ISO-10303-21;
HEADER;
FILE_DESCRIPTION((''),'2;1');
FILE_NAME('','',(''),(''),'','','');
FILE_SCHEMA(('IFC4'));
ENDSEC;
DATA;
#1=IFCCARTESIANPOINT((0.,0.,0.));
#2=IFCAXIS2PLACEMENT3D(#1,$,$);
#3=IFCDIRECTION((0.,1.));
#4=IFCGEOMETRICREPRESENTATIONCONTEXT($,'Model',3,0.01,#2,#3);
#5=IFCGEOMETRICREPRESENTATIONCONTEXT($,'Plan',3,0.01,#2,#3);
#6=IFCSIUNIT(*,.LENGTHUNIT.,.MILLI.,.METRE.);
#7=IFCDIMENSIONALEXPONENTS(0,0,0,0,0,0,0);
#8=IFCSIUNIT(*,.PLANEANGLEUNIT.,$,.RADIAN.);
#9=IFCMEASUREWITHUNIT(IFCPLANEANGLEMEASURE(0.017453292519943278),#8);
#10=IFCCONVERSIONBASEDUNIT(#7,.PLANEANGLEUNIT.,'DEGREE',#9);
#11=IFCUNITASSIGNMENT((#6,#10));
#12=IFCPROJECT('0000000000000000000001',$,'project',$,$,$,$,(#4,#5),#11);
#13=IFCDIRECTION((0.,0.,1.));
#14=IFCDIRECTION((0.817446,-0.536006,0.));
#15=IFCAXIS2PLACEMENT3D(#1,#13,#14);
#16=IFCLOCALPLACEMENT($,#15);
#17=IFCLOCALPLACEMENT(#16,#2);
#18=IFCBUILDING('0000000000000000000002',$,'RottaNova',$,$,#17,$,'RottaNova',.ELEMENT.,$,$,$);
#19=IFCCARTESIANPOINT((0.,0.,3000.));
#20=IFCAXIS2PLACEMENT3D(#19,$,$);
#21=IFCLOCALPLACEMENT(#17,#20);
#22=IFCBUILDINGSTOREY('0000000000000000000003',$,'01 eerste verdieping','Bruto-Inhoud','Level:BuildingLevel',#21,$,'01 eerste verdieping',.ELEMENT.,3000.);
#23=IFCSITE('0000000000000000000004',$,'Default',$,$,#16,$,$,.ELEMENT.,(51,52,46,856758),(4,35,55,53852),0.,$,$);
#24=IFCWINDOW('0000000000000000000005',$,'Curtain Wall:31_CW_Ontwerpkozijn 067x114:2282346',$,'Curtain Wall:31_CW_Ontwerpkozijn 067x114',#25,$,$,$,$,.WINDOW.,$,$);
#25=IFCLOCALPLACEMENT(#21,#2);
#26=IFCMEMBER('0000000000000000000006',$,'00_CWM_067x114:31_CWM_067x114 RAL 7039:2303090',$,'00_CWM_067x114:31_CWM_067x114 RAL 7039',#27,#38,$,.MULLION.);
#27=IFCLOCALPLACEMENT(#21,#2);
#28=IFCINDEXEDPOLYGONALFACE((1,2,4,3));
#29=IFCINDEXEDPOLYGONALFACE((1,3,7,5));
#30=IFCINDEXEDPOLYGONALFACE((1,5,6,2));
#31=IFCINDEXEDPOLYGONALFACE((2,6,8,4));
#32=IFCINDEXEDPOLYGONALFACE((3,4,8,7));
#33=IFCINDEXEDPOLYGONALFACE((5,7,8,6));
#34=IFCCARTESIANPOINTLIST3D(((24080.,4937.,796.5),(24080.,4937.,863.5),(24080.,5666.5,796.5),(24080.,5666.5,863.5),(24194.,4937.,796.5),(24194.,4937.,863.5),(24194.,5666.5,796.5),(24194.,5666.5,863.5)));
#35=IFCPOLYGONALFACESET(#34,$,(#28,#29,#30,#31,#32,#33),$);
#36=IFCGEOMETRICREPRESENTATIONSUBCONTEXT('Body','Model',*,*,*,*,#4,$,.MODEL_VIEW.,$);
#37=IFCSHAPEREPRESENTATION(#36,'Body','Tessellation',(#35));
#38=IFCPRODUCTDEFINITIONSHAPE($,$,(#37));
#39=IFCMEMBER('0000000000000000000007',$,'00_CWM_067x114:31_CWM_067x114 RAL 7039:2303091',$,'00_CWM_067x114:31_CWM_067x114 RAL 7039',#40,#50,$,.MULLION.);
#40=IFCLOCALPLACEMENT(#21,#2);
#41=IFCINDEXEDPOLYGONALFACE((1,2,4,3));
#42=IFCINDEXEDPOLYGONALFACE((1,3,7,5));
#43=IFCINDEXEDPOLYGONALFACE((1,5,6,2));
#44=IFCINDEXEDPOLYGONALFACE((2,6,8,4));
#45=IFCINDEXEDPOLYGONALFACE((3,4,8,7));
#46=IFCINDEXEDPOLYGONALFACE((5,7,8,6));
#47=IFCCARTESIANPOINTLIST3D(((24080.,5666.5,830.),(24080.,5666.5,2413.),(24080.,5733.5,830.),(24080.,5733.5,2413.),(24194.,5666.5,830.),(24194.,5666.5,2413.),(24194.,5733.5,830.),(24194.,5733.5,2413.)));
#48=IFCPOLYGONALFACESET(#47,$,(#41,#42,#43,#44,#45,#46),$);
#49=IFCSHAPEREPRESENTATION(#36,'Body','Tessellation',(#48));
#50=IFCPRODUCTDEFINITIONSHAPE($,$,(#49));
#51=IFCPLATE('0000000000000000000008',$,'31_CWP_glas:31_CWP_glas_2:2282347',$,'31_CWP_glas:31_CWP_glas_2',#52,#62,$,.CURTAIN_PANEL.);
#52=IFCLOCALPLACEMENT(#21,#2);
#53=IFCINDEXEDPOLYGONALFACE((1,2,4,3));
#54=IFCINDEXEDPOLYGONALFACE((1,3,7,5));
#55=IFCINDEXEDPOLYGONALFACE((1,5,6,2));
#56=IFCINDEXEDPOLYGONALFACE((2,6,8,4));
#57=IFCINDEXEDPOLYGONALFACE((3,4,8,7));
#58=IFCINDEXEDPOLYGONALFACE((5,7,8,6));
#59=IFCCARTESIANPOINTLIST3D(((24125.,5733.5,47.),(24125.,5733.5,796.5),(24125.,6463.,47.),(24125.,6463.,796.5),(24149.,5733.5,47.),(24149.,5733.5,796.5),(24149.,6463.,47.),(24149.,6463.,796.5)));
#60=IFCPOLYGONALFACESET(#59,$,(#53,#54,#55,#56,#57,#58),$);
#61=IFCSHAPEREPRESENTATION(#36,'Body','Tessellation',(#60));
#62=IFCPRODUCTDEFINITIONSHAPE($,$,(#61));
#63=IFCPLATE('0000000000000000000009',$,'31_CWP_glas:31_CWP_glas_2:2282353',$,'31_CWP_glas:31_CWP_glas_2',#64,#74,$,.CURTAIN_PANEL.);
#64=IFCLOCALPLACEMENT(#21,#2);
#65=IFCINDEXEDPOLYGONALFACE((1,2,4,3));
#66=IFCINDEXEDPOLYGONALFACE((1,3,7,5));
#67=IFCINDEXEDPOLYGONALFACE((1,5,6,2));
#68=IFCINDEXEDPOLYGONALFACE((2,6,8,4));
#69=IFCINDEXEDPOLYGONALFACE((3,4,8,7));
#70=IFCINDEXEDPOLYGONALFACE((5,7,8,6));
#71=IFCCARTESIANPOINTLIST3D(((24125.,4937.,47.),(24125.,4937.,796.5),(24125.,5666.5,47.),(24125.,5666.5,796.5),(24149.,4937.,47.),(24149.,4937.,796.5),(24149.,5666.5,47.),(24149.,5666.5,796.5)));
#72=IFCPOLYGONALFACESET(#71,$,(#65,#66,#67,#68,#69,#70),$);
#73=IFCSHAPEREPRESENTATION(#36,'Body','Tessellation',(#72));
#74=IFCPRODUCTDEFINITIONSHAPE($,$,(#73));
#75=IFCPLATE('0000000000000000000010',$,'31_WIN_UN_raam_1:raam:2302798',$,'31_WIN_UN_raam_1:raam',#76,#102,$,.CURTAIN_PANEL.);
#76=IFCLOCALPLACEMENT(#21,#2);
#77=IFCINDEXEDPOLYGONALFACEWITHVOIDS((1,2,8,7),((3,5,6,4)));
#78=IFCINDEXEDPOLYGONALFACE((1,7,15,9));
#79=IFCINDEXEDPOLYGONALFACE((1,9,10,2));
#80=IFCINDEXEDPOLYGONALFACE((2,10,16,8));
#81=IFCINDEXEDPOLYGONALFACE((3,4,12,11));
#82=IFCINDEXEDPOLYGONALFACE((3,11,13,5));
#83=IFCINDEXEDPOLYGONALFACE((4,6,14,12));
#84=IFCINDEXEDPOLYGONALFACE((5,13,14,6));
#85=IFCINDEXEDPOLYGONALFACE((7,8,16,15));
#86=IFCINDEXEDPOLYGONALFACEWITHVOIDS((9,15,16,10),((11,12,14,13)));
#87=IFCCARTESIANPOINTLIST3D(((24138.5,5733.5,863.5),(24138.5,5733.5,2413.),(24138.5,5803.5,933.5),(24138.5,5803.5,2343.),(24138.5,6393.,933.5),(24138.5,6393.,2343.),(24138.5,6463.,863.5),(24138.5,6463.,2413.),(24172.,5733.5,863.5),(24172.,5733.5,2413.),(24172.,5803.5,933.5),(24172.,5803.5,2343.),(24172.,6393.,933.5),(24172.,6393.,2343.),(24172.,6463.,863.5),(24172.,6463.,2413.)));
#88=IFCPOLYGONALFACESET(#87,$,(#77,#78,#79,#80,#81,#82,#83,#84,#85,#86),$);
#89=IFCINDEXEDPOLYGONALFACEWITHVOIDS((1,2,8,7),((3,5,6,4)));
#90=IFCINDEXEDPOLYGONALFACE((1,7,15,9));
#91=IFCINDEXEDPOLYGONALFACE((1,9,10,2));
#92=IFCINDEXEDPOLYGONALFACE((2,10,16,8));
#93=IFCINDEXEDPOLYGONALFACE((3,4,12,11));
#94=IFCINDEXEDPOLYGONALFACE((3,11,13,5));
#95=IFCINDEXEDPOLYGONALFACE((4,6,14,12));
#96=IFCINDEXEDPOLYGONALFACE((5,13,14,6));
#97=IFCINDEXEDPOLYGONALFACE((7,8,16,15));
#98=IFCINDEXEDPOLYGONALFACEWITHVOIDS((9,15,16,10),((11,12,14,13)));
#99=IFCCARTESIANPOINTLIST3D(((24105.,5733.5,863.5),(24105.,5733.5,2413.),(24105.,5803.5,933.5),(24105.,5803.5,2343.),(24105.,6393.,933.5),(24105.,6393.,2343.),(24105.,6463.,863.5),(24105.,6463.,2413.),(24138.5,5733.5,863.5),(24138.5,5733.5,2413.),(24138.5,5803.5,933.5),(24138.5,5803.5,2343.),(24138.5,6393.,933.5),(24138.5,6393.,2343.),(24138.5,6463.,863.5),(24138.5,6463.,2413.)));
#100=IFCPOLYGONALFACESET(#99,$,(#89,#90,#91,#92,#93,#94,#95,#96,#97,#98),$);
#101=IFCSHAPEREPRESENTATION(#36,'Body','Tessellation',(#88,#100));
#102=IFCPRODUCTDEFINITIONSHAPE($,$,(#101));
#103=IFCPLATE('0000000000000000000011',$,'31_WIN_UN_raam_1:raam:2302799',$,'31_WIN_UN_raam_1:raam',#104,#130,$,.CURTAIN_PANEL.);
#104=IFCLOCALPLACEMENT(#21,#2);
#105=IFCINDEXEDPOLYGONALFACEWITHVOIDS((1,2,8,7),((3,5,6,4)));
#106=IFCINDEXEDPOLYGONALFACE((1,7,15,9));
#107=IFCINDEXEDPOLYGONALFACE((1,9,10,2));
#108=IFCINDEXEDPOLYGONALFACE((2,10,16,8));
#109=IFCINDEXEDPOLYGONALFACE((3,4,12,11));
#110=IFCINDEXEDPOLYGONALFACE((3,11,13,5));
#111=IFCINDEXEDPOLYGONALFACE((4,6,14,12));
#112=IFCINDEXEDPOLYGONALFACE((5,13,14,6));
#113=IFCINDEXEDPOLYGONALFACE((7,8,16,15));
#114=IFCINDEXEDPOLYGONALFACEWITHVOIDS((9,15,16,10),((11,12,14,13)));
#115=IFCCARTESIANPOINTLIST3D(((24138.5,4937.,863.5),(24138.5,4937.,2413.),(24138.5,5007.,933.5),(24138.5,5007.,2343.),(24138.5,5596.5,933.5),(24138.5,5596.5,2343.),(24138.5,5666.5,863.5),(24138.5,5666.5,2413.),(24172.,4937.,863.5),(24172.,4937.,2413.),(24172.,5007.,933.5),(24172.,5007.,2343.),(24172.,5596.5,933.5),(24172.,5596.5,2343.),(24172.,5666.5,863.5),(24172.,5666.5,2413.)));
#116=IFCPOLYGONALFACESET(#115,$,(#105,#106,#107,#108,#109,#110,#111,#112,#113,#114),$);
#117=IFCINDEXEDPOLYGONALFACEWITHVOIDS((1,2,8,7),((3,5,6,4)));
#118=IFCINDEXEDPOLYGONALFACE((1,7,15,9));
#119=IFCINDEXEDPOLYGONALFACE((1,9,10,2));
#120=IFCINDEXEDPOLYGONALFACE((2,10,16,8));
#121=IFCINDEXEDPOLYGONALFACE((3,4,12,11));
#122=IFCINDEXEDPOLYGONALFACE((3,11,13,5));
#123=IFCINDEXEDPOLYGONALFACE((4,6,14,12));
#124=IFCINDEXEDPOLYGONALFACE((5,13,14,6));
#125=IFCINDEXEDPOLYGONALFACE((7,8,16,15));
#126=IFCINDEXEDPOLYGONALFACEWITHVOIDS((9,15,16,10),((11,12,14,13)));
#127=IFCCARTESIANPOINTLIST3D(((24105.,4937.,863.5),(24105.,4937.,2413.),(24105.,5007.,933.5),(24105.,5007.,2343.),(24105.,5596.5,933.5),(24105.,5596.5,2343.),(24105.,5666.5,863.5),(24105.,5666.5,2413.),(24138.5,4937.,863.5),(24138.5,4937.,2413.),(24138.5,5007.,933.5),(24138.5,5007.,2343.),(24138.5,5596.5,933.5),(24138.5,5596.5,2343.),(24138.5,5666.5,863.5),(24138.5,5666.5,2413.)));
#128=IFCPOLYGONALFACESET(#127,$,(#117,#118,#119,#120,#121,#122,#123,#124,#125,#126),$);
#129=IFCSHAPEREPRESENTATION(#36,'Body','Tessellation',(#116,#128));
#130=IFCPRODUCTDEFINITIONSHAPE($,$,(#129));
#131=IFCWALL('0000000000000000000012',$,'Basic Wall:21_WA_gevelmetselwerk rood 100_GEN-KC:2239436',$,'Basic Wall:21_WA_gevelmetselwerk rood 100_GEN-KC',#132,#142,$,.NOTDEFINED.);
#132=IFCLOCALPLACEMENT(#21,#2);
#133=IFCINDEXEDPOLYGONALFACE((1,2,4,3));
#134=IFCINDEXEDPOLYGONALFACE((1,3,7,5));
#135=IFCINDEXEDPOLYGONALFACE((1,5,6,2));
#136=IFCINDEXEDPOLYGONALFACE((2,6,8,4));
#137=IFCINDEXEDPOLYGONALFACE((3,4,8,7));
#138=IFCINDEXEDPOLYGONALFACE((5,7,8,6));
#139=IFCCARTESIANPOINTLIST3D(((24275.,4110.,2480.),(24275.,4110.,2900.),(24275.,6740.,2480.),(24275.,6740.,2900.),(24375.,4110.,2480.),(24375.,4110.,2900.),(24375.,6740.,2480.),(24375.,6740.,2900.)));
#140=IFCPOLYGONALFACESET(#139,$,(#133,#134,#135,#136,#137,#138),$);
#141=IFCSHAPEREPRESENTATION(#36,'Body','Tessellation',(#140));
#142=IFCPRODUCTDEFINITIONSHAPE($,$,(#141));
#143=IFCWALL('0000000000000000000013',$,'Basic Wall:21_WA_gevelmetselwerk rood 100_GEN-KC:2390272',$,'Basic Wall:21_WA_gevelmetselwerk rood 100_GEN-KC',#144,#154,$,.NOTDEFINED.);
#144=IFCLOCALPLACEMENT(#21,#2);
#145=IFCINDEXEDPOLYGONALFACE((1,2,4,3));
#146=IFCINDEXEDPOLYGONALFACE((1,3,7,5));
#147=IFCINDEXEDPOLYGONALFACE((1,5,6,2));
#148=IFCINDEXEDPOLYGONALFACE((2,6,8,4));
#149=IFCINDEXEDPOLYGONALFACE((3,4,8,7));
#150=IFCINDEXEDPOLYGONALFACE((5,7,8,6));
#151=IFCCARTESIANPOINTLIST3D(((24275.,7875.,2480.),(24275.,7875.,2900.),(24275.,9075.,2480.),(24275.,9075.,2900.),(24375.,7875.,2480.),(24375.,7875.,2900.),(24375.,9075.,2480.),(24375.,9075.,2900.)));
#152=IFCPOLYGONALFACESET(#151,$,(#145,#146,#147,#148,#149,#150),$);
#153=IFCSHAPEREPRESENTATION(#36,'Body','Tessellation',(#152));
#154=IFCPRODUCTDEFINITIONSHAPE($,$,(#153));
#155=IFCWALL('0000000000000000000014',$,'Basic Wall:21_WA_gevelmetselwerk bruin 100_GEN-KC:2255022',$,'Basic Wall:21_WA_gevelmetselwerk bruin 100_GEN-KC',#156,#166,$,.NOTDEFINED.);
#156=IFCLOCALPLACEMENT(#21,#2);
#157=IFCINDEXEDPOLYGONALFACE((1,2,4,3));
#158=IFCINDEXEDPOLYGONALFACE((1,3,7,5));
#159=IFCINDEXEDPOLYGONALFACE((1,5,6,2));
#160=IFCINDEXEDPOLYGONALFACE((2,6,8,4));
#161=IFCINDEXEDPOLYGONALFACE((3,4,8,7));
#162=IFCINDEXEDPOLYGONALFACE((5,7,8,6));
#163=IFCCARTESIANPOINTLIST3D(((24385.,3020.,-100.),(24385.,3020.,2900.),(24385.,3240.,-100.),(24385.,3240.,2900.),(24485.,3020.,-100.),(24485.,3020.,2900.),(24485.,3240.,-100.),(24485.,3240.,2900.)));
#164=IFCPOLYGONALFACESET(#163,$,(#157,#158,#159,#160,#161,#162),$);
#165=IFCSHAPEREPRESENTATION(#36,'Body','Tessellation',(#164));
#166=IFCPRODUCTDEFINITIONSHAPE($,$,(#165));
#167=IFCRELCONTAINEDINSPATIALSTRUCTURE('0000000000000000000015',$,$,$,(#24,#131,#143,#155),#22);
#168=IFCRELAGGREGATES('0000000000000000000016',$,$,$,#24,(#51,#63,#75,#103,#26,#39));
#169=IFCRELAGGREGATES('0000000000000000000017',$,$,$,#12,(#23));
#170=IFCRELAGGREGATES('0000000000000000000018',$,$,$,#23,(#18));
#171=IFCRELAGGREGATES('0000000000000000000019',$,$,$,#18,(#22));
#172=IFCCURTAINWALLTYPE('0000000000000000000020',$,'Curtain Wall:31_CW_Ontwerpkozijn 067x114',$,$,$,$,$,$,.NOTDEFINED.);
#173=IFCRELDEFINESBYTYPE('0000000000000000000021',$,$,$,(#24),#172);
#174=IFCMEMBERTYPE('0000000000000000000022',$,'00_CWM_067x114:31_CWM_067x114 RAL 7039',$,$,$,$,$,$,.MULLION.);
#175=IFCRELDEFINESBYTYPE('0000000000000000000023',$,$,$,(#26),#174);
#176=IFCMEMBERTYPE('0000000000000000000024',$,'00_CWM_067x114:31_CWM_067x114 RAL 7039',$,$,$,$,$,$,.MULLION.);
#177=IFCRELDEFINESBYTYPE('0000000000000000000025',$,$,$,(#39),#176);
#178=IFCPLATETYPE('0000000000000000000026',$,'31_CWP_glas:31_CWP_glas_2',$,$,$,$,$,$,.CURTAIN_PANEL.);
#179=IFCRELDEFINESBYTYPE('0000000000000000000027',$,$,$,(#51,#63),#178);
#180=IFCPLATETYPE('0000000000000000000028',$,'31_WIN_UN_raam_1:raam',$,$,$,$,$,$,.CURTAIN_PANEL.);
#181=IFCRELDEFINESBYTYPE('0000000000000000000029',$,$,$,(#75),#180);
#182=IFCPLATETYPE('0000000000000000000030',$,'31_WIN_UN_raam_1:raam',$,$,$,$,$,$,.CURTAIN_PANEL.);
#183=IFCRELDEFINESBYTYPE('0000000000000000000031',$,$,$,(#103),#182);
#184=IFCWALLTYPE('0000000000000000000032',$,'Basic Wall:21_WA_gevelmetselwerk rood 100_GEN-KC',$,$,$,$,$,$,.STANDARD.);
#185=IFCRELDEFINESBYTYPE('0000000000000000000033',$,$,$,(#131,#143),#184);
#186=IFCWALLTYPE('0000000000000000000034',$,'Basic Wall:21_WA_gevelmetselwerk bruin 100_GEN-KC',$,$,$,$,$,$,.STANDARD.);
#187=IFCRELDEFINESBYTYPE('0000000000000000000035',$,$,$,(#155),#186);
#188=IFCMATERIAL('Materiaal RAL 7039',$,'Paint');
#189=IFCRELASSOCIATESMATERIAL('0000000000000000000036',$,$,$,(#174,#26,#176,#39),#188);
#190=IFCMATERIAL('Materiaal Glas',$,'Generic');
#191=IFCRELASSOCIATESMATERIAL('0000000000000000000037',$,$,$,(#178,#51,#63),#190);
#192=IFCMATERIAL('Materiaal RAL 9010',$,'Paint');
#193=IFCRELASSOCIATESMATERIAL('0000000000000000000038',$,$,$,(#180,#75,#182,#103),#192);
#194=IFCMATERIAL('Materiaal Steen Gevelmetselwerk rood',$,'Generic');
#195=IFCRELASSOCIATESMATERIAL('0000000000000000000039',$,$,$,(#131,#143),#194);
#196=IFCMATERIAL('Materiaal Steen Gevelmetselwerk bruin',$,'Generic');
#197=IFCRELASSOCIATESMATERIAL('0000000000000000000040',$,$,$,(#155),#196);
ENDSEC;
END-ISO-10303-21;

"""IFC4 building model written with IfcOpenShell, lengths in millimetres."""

from ifc_helpers import new_model, entity, si_unit, converted_unit, direction, frame, origin, place, context, subcontext, project, spatial, indexed_curve, outline, extrude, source, transform, mapped, material, type_object, type_shapes, element, aggregate, save


model = new_model("IFC4")

# Units and contexts
model_context = context("Model", 3, precision=0.01, world=origin(), true_north=direction((0.0, 1.0)))
plan_context = context("Plan", 3, precision=0.01, world=origin(), true_north=direction((0.0, 1.0)))
body_context = subcontext(model_context, "Body", "Model", "MODEL_VIEW")
ifc_project = project(units=[si_unit("LENGTHUNIT", "METRE", prefix="MILLI"), converted_unit("PLANEANGLEUNIT", "DEGREE", entity("IfcPlaneAngleMeasure", 0.017453292519943278), si_unit("PLANEANGLEUNIT", "RADIAN"), dimensions=[0, 0, 0, 0, 0, 0, 0])], contexts=[model_context, plan_context])

# Site, building, storey
site_placement = place(None, frame((0.0, 0.0, 0.0), z_axis=(0.0, 0.0, 1.0), x_axis=(0.817446, -0.536006, 0.0)))
site = spatial("IfcSite", under=ifc_project, at=site_placement, Name="Default", CompositionType="ELEMENT", RefLatitude=(51, 52, 46, 856758), RefLongitude=(4, 35, 55, 53852), RefElevation=0.0)
building_placement = place(site_placement, origin())
building = spatial("IfcBuilding", under=site, at=building_placement, Name="RottaNova", LongName="RottaNova", CompositionType="ELEMENT")
storey_placement = place(building_placement, frame((0.0, 0.0, 3000.0)))
storey = spatial("IfcBuildingStorey", under=building, at=storey_placement, Name="01 eerste verdieping", Description="Bruto-Inhoud", ObjectType="Level:BuildingLevel", LongName="01 eerste verdieping", CompositionType="ELEMENT", Elevation=3000.0)

# Window, members, plates
curtain_wall_type = type_object("IfcCurtainWallType", Name="Curtain Wall:31_CW_Ontwerpkozijn 067x114", PredefinedType="NOTDEFINED")
window_placement = place(storey_placement, frame((0.0, 0.0, -3000.0)))
window = element("IfcWindow", 1, at=window_placement, inside=storey, type_object=curtain_wall_type, Name="Curtain Wall:31_CW_Ontwerpkozijn 067x114:2282346", ObjectType="Curtain Wall:31_CW_Ontwerpkozijn 067x114", PredefinedType="WINDOW")
ifc_material_1 = material(Name="Materiaal RAL 7039", Category="Paint")
member_type_1 = type_object("IfcMemberType", Name="00_CWM_067x114:31_CWM_067x114 RAL 7039", PredefinedType="MULLION", material=ifc_material_1)
shared_shape_1 = source(origin(), body_context, "Body", "SweptSolid", [
    extrude(outline(indexed_curve([(-33.5, -57.0), (33.5, -57.0), (33.5, 57.0), (-33.5, 57.0), (-33.5, -57.0)], self_intersect=False)), frame((0.0, -57.0, -729.5), z_axis=(0.0, 0.0, 1.0), x_axis=(-1.0, 0.0, 0.0)), (0.0, 0.0, 1.0), 729.5),
])
type_shapes(member_type_1, [shared_shape_1])
member_1_placement = place(window_placement, frame((24080.0, 4937.0, 3830.0), z_axis=(0.0, -1.0, 0.0), x_axis=(0.0, 0.0, 1.0)))
member_1 = element("IfcMember", 2, at=member_1_placement, type_object=member_type_1, material=ifc_material_1, Name="00_CWM_067x114:31_CWM_067x114 RAL 7039:2303090", ObjectType="00_CWM_067x114:31_CWM_067x114 RAL 7039", PredefinedType="MULLION", context=body_context, shape_type="MappedRepresentation", body=[
    mapped(shared_shape_1, transform((0.0, 0.0, 0.0), scale=1.0)),
])
member_type_2 = type_object("IfcMemberType", Name="00_CWM_067x114:31_CWM_067x114 RAL 7039", PredefinedType="MULLION", material=ifc_material_1)
shared_shape_2 = source(origin(), body_context, "Body", "SweptSolid", [
    extrude(outline(indexed_curve([(-33.5, -57.0), (33.5, -57.0), (33.5, 57.0), (-33.5, 57.0), (-33.5, -57.0)], self_intersect=False)), frame((0.0, -57.0, -1583.0), z_axis=(0.0, 0.0, 1.0), x_axis=(-1.0, 0.0, 0.0)), (0.0, 0.0, 1.0), 1583.0),
])
type_shapes(member_type_2, [shared_shape_2])
member_2_placement = place(window_placement, frame((24080.0, 5700.0, 3830.0), z_axis=(0.0, 0.0, -1.0), x_axis=(0.0, -1.0, 0.0)))
member_2 = element("IfcMember", 3, at=member_2_placement, type_object=member_type_2, material=ifc_material_1, Name="00_CWM_067x114:31_CWM_067x114 RAL 7039:2303091", ObjectType="00_CWM_067x114:31_CWM_067x114 RAL 7039", PredefinedType="MULLION", context=body_context, shape_type="MappedRepresentation", body=[
    mapped(shared_shape_2, transform((0.0, 0.0, 0.0), scale=1.0)),
])
ifc_material_2 = material(Name="Materiaal Glas", Category="Generic")
plate_type_1 = type_object("IfcPlateType", Name="31_CWP_glas:31_CWP_glas_2", PredefinedType="CURTAIN_PANEL", material=ifc_material_2)
shared_shape_3 = source(origin(), body_context, "Body", "SweptSolid", [
    extrude(outline(indexed_curve([(-12.0, -364.7), (12.0, -364.7), (12.0, 364.7), (-12.0, 364.7), (-12.0, -364.7)], self_intersect=False)), frame((0.0, 57.0, 0.0), z_axis=(0.0, 0.0, 1.0), x_axis=(0.0, 1.0, 0.0)), (0.0, 0.0, 1.0), 749.5),
])
type_shapes(plate_type_1, [shared_shape_3])
plate_1_placement = place(window_placement, frame((24080.0, 6098.2, 3047.0), z_axis=(0.0, 0.0, 1.0), x_axis=(0.0, -1.0, 0.0)))
plate_1 = element("IfcPlate", 4, at=plate_1_placement, type_object=plate_type_1, material=ifc_material_2, Name="31_CWP_glas:31_CWP_glas_2:2282347", ObjectType="31_CWP_glas:31_CWP_glas_2", PredefinedType="CURTAIN_PANEL", context=body_context, shape_type="MappedRepresentation", body=[
    mapped(shared_shape_3, transform((0.0, 0.0, 0.0), scale=1.0)),
])
plate_2_placement = place(window_placement, frame((24080.0, 5301.7, 3047.0), z_axis=(0.0, 0.0, 1.0), x_axis=(0.0, -1.0, 0.0)))
plate_2 = element("IfcPlate", 5, at=plate_2_placement, type_object=plate_type_1, material=ifc_material_2, Name="31_CWP_glas:31_CWP_glas_2:2282353", ObjectType="31_CWP_glas:31_CWP_glas_2", PredefinedType="CURTAIN_PANEL", context=body_context, shape_type="MappedRepresentation", body=[
    mapped(shared_shape_3, transform((0.0, 0.0, 0.0), scale=1.0)),
])
ifc_material_3 = material(Name="Materiaal RAL 9010", Category="Paint")
plate_type_2 = type_object("IfcPlateType", Name="31_WIN_UN_raam_1:raam", PredefinedType="CURTAIN_PANEL", material=ifc_material_3)
shared_shape_4 = source(origin(), body_context, "Body", "SweptSolid", [
    extrude(outline(indexed_curve([(-364.7, -774.7), (364.7, -774.7), (364.7, 774.7), (-364.7, 774.7), (-364.7, -774.7)], self_intersect=False), holes=[indexed_curve([(-294.7, 704.7), (294.7, 704.7), (294.7, -704.8), (-294.7, -704.8), (-294.7, 704.7)], self_intersect=False)]), frame((0.0, 58.5, 774.8), z_axis=(0.0, 1.0, 0.0), x_axis=(1.0, 0.0, 0.0)), (0.0, 0.0, 1.0), 33.5),
    extrude(outline(indexed_curve([(-364.7, -774.7), (364.7, -774.7), (364.7, 774.7), (-364.7, 774.7), (-364.7, -774.7)], self_intersect=False), holes=[indexed_curve([(-294.7, 704.7), (294.7, 704.7), (294.7, -704.8), (-294.7, -704.8), (-294.7, 704.7)], self_intersect=False)]), frame((0.0, 25.0, 774.8), z_axis=(0.0, 1.0, 0.0), x_axis=(1.0, 0.0, 0.0)), (0.0, 0.0, 1.0), 33.5),
])
type_shapes(plate_type_2, [shared_shape_4])
plate_3_placement = place(window_placement, frame((24080.0, 6098.2, 3863.5), z_axis=(0.0, 0.0, 1.0), x_axis=(0.0, -1.0, 0.0)))
plate_3 = element("IfcPlate", 6, at=plate_3_placement, type_object=plate_type_2, material=ifc_material_3, Name="31_WIN_UN_raam_1:raam:2302798", ObjectType="31_WIN_UN_raam_1:raam", PredefinedType="CURTAIN_PANEL", context=body_context, shape_type="MappedRepresentation", body=[
    mapped(shared_shape_4, transform((0.0, 0.0, 0.0), scale=1.0)),
])
plate_type_3 = type_object("IfcPlateType", Name="31_WIN_UN_raam_1:raam", PredefinedType="CURTAIN_PANEL", material=ifc_material_3)
shared_shape_5 = source(origin(), body_context, "Body", "SweptSolid", [
    extrude(outline(indexed_curve([(-364.7, -774.7), (364.7, -774.7), (364.7, 774.7), (-364.7, 774.7), (-364.7, -774.7)], self_intersect=False), holes=[indexed_curve([(-294.7, 704.7), (294.7, 704.7), (294.7, -704.8), (-294.7, -704.8), (-294.7, 704.7)], self_intersect=False)]), frame((0.0, 58.5, 774.8), z_axis=(0.0, 1.0, 0.0), x_axis=(1.0, 0.0, 0.0)), (0.0, 0.0, 1.0), 33.5),
    extrude(outline(indexed_curve([(-364.7, -774.7), (364.7, -774.7), (364.7, 774.7), (-364.7, 774.7), (-364.7, -774.7)], self_intersect=False), holes=[indexed_curve([(-294.7, 704.7), (294.7, 704.7), (294.7, -704.8), (-294.7, -704.8), (-294.7, 704.7)], self_intersect=False)]), frame((0.0, 25.0, 774.8), z_axis=(0.0, 1.0, 0.0), x_axis=(1.0, 0.0, 0.0)), (0.0, 0.0, 1.0), 33.5),
])
type_shapes(plate_type_3, [shared_shape_5])
plate_4_placement = place(window_placement, frame((24080.0, 5301.7, 3863.5), z_axis=(0.0, 0.0, 1.0), x_axis=(0.0, -1.0, 0.0)))
plate_4 = element("IfcPlate", 7, at=plate_4_placement, type_object=plate_type_3, material=ifc_material_3, Name="31_WIN_UN_raam_1:raam:2302799", ObjectType="31_WIN_UN_raam_1:raam", PredefinedType="CURTAIN_PANEL", context=body_context, shape_type="MappedRepresentation", body=[
    mapped(shared_shape_5, transform((0.0, 0.0, 0.0), scale=1.0)),
])
aggregate(window, [plate_1, plate_2, plate_3, plate_4, member_1, member_2])

# Walls
ifc_material_4 = material(Name="Materiaal Steen Gevelmetselwerk rood", Category="Generic")
wall_type_1 = type_object("IfcWallType", Name="Basic Wall:21_WA_gevelmetselwerk rood 100_GEN-KC", PredefinedType="STANDARD")
wall_1_placement = place(storey_placement, frame((24325.0, 4110.0, 2480.0), z_axis=(0.0, 0.0, 1.0), x_axis=(0.0, 1.0, 0.0)))
element("IfcWall", 8, at=wall_1_placement, inside=storey, type_object=wall_type_1, material=ifc_material_4, Name="Basic Wall:21_WA_gevelmetselwerk rood 100_GEN-KC:2239436", ObjectType="Basic Wall:21_WA_gevelmetselwerk rood 100_GEN-KC", PredefinedType="NOTDEFINED", context=body_context, shape_type="SweptSolid", body=[
    extrude(outline(indexed_curve([(2630.0, 50.0), (0.0, 50.0), (0.0, -50.0), (2630.0, -50.0), (2630.0, 50.0)], self_intersect=False)), origin(), (0.0, 0.0, 1.0), 420.0),
])
wall_2_placement = place(storey_placement, frame((24325.0, 7875.0, 2480.0), z_axis=(0.0, 0.0, 1.0), x_axis=(0.0, 1.0, 0.0)))
element("IfcWall", 9, at=wall_2_placement, inside=storey, type_object=wall_type_1, material=ifc_material_4, Name="Basic Wall:21_WA_gevelmetselwerk rood 100_GEN-KC:2390272", ObjectType="Basic Wall:21_WA_gevelmetselwerk rood 100_GEN-KC", PredefinedType="NOTDEFINED", context=body_context, shape_type="SweptSolid", body=[
    extrude(outline(indexed_curve([(1200.0, 50.0), (0.0, 50.0), (0.0, -50.0), (1200.0, -50.0), (1200.0, 50.0)], self_intersect=False)), origin(), (0.0, 0.0, 1.0), 420.0),
])
ifc_material_5 = material(Name="Materiaal Steen Gevelmetselwerk bruin", Category="Generic")
wall_type_2 = type_object("IfcWallType", Name="Basic Wall:21_WA_gevelmetselwerk bruin 100_GEN-KC", PredefinedType="STANDARD")
wall_3_placement = place(storey_placement, frame((24435.0, 3240.0, -100.0), z_axis=(0.0, 0.0, 1.0), x_axis=(0.0, -1.0, 0.0)))
element("IfcWall", 10, at=wall_3_placement, inside=storey, type_object=wall_type_2, material=ifc_material_5, Name="Basic Wall:21_WA_gevelmetselwerk bruin 100_GEN-KC:2255022", ObjectType="Basic Wall:21_WA_gevelmetselwerk bruin 100_GEN-KC", PredefinedType="NOTDEFINED", context=body_context, shape_type="SweptSolid", body=[
    extrude(outline(indexed_curve([(220.0, 50.0), (0.0, 50.0), (0.0, -50.0), (220.0, -50.0), (220.0, 50.0)], self_intersect=False)), origin(), (0.0, 0.0, 1.0), 3000.0),
])

save(model, "model.ifc")
